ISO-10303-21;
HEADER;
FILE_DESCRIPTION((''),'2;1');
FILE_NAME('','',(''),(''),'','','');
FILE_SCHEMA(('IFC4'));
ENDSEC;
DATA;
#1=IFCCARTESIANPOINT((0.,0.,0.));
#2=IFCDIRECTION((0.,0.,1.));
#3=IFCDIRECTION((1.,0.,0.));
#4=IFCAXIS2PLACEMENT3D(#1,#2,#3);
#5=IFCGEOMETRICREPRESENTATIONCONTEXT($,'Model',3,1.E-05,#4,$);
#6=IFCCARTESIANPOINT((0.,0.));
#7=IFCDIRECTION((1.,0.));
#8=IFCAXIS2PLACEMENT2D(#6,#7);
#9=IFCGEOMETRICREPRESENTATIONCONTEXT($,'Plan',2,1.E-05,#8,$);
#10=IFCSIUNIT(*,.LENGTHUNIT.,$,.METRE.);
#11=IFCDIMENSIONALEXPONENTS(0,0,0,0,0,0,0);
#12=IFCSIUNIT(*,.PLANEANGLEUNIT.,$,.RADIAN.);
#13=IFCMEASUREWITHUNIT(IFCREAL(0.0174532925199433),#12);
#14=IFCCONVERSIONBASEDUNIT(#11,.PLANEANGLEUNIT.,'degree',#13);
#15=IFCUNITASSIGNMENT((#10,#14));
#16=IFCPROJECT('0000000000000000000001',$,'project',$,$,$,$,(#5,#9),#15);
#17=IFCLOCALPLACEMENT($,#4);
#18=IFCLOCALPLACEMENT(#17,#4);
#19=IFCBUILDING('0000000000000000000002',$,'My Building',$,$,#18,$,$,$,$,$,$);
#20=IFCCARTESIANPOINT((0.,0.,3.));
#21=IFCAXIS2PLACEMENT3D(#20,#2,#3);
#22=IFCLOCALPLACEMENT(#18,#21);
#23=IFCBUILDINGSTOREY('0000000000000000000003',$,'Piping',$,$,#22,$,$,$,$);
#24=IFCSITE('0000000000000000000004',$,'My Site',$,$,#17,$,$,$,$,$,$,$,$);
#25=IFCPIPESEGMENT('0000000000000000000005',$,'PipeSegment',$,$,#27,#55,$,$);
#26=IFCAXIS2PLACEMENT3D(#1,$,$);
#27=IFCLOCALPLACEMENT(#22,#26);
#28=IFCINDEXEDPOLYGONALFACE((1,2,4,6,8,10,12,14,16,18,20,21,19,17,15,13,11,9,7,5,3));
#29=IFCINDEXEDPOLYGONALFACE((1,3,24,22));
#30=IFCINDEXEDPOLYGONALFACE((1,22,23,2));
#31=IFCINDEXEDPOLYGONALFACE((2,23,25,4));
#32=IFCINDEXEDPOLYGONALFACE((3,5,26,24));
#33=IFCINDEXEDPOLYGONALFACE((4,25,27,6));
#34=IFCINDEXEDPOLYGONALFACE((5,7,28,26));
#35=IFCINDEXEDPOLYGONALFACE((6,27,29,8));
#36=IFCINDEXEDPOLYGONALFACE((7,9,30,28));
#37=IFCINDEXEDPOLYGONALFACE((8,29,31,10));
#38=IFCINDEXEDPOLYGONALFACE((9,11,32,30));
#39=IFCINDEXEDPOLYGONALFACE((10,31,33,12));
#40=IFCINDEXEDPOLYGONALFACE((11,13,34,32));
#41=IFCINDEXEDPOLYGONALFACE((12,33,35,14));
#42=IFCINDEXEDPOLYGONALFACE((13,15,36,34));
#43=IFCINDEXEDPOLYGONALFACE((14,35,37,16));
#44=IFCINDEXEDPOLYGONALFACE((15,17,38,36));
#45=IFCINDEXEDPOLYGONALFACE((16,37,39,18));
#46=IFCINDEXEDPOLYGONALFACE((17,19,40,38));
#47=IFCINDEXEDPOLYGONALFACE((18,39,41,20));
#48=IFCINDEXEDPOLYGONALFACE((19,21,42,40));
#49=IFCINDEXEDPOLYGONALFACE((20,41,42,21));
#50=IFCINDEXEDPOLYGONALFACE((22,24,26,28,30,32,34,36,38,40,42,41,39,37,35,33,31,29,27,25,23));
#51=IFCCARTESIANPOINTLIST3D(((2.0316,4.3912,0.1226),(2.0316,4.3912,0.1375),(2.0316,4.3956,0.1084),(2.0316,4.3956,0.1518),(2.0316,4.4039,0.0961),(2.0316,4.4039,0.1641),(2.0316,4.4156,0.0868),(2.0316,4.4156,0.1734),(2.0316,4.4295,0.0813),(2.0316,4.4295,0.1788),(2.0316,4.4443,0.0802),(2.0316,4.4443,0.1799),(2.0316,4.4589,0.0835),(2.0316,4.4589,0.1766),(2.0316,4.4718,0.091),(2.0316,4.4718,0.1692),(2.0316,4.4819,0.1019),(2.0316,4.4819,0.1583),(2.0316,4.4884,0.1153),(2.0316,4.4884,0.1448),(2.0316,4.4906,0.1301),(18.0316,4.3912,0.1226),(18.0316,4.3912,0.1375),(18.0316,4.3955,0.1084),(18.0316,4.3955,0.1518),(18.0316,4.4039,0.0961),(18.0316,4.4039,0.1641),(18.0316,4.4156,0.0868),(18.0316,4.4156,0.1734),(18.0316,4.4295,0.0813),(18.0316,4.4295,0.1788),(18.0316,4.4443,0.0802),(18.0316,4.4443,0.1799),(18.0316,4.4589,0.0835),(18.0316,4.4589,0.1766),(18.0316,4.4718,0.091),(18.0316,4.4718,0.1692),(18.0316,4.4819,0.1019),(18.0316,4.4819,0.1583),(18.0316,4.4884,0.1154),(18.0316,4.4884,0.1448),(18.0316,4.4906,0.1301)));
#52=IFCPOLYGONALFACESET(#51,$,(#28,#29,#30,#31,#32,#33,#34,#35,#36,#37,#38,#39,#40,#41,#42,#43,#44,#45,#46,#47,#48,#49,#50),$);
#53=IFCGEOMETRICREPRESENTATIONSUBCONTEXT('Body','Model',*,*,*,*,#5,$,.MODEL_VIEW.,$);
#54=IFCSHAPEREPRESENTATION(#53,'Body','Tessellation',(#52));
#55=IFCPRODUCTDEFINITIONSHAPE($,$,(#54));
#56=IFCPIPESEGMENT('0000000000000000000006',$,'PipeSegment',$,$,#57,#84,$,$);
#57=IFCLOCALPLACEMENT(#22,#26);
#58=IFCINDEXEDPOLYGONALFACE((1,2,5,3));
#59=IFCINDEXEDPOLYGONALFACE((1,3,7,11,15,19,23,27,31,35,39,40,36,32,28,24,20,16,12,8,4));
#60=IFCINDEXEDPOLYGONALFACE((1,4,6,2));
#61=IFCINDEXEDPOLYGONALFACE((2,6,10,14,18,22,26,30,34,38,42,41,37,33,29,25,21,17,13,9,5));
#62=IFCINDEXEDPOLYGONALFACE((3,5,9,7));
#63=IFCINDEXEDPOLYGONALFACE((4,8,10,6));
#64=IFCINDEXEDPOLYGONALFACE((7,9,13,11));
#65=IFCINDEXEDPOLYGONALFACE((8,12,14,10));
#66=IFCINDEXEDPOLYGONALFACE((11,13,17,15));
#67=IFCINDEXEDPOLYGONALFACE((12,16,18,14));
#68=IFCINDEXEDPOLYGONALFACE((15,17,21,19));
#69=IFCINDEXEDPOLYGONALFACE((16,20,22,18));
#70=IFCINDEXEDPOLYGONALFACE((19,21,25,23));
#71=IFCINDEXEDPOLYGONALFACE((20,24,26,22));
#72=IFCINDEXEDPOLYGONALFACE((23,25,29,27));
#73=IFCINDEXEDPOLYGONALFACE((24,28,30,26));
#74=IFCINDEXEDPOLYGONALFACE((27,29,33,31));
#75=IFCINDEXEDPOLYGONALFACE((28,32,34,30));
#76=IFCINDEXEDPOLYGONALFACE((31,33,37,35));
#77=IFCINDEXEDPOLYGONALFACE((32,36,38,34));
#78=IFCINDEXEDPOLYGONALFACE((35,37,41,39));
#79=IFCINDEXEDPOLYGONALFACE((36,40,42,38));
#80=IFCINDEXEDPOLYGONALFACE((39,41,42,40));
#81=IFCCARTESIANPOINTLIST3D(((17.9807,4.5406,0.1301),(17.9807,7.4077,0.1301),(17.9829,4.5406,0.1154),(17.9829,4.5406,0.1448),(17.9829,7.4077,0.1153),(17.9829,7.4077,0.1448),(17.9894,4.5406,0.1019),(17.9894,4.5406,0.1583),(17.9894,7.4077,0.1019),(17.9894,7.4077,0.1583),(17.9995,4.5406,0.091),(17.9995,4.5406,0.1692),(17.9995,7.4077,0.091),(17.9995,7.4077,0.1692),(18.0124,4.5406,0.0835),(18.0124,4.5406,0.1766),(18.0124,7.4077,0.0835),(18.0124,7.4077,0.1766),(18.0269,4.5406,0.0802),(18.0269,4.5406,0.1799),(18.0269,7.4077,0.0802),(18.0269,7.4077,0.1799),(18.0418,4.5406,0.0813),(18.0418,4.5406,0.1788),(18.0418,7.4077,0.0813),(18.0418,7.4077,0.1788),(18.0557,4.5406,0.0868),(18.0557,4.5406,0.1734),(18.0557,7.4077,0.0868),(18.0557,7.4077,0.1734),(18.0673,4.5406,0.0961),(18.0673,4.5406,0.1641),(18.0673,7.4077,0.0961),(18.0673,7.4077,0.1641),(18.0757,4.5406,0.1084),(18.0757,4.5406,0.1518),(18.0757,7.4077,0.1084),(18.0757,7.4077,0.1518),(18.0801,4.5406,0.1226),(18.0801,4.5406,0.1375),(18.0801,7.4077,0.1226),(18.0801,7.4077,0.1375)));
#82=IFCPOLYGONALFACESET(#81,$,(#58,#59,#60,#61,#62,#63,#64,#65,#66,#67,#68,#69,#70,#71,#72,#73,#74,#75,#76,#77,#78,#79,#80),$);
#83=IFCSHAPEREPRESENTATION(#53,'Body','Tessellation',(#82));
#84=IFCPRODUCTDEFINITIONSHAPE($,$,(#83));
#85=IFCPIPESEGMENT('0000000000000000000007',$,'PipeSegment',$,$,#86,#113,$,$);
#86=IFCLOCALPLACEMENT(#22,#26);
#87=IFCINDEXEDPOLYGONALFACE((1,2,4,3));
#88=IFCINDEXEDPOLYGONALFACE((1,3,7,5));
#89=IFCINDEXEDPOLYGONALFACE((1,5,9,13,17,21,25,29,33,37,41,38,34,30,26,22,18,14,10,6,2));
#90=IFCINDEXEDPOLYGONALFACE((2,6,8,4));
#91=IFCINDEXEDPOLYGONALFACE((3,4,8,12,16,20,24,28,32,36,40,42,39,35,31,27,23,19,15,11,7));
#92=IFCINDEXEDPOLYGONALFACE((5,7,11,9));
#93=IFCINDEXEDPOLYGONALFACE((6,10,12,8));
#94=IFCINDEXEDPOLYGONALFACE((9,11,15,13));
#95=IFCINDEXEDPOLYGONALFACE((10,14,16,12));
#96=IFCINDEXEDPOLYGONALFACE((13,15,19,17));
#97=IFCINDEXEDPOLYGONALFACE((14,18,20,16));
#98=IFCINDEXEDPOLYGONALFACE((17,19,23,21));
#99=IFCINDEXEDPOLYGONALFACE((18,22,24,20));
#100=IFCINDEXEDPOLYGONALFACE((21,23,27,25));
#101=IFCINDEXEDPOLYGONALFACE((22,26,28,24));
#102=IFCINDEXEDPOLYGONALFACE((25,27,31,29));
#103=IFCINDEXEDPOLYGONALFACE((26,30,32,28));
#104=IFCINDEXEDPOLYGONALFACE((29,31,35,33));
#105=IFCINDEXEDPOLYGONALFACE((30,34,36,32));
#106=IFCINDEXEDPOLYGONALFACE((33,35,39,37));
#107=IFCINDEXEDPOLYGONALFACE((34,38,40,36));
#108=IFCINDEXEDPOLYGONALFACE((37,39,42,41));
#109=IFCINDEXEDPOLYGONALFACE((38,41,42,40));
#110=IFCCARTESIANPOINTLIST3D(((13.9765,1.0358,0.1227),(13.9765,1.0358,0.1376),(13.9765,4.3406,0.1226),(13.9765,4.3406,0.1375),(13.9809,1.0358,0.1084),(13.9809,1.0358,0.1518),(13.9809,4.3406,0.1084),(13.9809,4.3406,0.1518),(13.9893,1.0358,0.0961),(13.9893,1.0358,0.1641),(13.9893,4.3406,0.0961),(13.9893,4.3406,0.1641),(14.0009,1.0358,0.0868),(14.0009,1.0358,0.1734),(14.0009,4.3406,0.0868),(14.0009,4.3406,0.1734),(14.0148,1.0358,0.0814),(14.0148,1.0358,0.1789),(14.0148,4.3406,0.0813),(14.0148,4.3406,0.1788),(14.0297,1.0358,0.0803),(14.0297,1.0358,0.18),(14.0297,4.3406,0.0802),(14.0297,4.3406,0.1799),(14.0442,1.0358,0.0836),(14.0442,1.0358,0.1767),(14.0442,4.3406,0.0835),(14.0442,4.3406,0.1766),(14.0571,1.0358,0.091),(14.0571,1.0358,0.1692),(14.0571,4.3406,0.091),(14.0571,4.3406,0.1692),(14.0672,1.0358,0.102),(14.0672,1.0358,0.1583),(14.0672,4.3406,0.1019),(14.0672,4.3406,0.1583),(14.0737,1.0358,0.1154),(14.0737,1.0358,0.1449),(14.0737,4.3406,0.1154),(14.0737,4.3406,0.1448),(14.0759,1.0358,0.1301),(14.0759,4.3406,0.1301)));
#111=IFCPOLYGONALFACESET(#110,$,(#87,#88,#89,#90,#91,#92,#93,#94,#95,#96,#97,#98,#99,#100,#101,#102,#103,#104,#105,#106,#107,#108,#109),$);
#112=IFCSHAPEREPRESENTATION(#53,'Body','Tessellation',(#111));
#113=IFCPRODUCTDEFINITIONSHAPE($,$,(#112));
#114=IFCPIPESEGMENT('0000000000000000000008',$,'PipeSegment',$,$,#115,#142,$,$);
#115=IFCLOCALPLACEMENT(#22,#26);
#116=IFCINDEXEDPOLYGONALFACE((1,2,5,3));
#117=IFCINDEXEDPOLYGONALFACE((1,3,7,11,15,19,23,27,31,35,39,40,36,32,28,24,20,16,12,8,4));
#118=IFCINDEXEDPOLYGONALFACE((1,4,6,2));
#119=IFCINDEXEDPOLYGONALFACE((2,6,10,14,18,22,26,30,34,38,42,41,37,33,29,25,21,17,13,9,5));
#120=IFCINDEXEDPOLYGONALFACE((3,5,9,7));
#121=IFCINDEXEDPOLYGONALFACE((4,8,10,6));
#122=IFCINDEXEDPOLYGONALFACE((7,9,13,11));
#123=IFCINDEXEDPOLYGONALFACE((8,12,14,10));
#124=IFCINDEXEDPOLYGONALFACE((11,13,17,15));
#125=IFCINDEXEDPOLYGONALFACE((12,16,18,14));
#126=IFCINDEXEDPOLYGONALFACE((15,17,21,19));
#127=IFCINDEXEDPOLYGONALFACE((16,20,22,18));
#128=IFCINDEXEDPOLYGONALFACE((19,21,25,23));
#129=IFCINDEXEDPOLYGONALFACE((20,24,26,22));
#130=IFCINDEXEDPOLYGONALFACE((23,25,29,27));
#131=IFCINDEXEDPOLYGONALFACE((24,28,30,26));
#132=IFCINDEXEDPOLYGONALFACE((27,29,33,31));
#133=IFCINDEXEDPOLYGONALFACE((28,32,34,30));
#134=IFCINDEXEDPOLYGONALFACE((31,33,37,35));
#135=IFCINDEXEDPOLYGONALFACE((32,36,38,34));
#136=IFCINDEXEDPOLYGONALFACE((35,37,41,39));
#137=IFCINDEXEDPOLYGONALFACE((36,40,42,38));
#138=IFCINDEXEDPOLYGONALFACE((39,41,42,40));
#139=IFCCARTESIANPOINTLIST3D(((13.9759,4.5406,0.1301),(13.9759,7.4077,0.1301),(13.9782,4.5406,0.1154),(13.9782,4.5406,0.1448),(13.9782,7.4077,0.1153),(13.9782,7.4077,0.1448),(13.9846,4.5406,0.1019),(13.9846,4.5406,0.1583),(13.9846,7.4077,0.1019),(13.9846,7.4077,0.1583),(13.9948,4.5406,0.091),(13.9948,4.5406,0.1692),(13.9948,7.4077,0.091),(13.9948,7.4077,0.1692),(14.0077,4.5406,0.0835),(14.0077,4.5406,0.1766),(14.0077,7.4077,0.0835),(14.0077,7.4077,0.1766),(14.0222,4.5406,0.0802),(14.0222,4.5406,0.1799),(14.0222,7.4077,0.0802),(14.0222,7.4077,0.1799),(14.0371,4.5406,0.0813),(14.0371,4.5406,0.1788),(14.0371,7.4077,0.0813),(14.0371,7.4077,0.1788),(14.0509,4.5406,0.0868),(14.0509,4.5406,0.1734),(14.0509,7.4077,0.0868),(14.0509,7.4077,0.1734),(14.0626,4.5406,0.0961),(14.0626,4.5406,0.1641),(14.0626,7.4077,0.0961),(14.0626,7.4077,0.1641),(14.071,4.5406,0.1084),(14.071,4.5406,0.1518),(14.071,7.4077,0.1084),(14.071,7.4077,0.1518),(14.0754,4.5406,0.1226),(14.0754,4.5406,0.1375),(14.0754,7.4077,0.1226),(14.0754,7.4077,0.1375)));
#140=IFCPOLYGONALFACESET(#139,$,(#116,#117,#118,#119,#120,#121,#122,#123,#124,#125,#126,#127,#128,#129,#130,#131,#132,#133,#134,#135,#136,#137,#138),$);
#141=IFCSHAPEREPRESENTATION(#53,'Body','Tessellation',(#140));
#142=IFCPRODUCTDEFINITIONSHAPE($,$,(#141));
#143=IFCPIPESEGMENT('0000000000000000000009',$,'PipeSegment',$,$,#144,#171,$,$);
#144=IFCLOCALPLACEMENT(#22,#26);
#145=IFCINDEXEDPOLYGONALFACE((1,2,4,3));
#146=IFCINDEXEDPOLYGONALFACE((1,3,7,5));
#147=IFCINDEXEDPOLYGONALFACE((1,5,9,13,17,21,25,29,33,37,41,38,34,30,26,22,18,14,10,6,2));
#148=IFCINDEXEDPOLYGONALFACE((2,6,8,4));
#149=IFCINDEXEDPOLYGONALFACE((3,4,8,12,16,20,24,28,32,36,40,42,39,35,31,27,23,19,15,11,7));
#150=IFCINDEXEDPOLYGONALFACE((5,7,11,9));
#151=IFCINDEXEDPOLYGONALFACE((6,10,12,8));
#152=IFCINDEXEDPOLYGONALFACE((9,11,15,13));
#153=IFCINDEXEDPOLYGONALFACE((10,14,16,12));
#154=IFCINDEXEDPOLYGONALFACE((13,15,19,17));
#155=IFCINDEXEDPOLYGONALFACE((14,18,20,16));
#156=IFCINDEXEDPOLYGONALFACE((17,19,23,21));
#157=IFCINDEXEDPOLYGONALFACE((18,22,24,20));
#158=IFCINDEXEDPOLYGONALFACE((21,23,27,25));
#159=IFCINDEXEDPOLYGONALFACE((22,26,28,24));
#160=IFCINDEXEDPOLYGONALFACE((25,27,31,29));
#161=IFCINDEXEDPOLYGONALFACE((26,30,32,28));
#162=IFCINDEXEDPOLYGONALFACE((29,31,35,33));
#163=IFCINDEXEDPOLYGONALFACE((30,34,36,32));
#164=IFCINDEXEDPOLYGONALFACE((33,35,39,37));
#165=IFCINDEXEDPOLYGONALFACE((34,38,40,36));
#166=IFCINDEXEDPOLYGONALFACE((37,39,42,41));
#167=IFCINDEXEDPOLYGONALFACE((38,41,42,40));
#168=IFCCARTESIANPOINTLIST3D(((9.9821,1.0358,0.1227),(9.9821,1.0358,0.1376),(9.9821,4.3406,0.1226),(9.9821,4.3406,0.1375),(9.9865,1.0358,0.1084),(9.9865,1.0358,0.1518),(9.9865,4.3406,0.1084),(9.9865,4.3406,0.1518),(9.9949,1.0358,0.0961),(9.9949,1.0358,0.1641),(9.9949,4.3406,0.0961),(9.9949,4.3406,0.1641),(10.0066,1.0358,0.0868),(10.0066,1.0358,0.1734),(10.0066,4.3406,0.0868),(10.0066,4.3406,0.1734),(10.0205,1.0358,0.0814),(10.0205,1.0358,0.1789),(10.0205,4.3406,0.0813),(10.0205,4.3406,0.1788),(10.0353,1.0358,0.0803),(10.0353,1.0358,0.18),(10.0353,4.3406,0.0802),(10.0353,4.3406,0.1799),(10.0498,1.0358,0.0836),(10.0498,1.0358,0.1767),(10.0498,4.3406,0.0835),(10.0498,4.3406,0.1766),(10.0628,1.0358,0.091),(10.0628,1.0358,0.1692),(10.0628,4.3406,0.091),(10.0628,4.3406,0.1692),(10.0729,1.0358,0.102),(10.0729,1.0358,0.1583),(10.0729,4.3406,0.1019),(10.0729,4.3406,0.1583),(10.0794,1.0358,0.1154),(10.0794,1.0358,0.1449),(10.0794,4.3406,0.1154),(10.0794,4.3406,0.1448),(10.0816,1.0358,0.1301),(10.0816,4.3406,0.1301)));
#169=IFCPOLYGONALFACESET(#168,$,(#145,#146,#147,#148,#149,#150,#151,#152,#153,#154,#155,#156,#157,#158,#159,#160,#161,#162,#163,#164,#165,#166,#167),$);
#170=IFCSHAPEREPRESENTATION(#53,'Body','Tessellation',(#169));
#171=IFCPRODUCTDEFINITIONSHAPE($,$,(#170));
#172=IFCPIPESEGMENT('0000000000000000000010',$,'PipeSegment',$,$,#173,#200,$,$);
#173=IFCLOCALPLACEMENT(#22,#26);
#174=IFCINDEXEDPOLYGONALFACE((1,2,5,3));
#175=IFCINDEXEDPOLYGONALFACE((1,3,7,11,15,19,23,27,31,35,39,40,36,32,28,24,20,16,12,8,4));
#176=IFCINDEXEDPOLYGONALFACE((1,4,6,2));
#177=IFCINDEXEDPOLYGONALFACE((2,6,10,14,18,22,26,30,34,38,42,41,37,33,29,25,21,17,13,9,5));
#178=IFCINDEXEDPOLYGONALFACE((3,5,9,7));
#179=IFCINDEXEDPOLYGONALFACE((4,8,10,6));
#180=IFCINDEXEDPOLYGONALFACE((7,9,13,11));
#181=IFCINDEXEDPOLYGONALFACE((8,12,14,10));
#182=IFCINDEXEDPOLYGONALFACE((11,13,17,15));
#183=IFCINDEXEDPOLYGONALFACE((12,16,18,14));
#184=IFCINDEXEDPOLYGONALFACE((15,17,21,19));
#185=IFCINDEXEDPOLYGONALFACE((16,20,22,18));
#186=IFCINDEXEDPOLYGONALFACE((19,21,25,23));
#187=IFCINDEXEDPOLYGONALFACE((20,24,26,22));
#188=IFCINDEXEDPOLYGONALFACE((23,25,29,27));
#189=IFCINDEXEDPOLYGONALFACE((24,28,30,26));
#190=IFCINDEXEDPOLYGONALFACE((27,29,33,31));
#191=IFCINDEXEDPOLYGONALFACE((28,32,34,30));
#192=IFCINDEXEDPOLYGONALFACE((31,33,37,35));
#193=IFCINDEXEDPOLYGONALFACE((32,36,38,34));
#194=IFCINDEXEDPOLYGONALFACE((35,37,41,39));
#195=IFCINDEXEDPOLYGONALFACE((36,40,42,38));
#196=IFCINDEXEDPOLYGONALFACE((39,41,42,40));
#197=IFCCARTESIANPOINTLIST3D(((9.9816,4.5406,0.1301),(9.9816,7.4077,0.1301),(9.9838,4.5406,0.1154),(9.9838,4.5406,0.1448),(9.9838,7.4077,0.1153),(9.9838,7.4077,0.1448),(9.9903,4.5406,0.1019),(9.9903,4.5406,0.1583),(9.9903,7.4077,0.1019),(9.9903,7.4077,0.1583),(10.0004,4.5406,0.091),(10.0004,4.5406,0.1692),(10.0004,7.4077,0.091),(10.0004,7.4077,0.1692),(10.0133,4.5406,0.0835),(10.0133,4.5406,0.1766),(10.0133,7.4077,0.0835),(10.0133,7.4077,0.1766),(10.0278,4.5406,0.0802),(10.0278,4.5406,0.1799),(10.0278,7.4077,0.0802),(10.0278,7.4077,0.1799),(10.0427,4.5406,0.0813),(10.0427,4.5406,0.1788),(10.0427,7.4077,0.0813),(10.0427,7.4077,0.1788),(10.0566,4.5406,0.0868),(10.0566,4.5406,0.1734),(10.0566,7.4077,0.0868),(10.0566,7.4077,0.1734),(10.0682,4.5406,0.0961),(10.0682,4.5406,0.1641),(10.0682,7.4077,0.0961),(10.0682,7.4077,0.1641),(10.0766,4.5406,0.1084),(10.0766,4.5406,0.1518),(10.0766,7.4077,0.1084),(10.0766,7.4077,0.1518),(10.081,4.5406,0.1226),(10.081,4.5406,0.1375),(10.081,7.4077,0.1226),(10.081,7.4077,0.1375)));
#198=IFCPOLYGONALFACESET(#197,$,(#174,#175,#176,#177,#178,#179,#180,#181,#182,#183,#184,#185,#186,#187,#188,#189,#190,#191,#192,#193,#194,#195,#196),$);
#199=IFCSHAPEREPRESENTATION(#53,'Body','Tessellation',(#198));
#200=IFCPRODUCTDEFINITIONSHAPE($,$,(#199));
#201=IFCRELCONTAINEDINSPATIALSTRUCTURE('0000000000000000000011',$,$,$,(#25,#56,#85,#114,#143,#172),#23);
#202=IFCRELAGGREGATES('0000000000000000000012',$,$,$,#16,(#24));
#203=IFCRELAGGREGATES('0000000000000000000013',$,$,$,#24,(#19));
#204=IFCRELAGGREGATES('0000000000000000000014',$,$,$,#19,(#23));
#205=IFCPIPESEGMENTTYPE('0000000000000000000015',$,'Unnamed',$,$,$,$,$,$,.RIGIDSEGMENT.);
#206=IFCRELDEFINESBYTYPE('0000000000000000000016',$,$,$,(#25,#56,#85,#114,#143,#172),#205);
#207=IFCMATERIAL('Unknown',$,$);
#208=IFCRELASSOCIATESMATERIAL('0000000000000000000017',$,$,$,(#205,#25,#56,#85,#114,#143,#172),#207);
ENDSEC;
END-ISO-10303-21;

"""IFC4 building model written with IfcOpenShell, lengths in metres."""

from ifc_helpers import new_model, entity, si_unit, converted_unit, frame, origin_with_axes, origin_2d_with_axis, place, context, subcontext, project, spatial, circle, extrude, material, material_profile, profile_set, profile_usage, type_object, element, save


model = new_model("IFC4")

# Units and contexts
model_context = context("Model", 3, precision=1e-05, world=origin_with_axes())
plan_context = context("Plan", 2, precision=1e-05, world=origin_2d_with_axis())
body_context = subcontext(model_context, "Body", "Model", "MODEL_VIEW")
ifc_project = project(units=[si_unit("LENGTHUNIT", "METRE"), converted_unit("PLANEANGLEUNIT", "degree", entity("IfcReal", 0.0174532925199433), si_unit("PLANEANGLEUNIT", "RADIAN"), dimensions=[0, 0, 0, 0, 0, 0, 0])], contexts=[model_context, plan_context])

# Site, building, storey
site_placement = place(None, origin_with_axes())
site = spatial("IfcSite", under=ifc_project, at=site_placement, Name="My Site")
building_placement = place(site_placement, origin_with_axes())
building = spatial("IfcBuilding", under=site, at=building_placement, Name="My Building")
storey_placement = place(building_placement, frame((0.0, 0.0, 3.0), z_axis=(0.0, 0.0, 1.0), x_axis=(1.0, 0.0, 0.0)))
storey = spatial("IfcBuildingStorey", under=building, at=storey_placement, Name="Piping")

# Pipe segments
ifc_material = material(Name="Unknown")
ifc_material_profile_1 = material_profile(ifc_material, circle(Radius=0.05))
ifc_profile_set_1 = profile_set([ifc_material_profile_1])
ifc_profile_usage_1 = profile_usage(ifc_profile_set_1, cardinal=5)
pipe_segment_type = type_object("IfcPipeSegmentType", Name="Unnamed", PredefinedType="RIGIDSEGMENT", material=ifc_profile_set_1)
pipe_segment_1_placement = place(storey_placement, frame((2.0316, 4.4406, 0.1301), z_axis=(1.0, 0.0, 0.0), x_axis=(0.0, 1.0, 0.0)))
element("IfcPipeSegment", 1, at=pipe_segment_1_placement, inside=storey, type_object=pipe_segment_type, material=ifc_profile_usage_1, Name="PipeSegment", context=body_context, shape_type="SweptSolid", body=[
    extrude(circle(Radius=0.05), origin_with_axes(), (0.0, 0.0, 1.0), 16.0),
])
ifc_profile_usage_2 = profile_usage(ifc_profile_set_1, cardinal=5)
pipe_segment_2_placement = place(storey_placement, frame((18.0307, 4.5406, 0.1301), z_axis=(0.0, 1.0, -0.000001), x_axis=(-1.0, 0.0, 0.0)))
element("IfcPipeSegment", 2, at=pipe_segment_2_placement, inside=storey, type_object=pipe_segment_type, material=ifc_profile_usage_2, Name="PipeSegment", context=body_context, shape_type="SweptSolid", body=[
    extrude(circle(Radius=0.05), origin_with_axes(), (0.0, 0.0, 1.0), 2.8671),
])
ifc_profile_usage_3 = profile_usage(ifc_profile_set_1, cardinal=5)
pipe_segment_3_placement = place(storey_placement, frame((14.0259, 4.3406, 0.1301), z_axis=(0.0, -1.0, 0.000015), x_axis=(1.0, 0.0, 0.0)))
element("IfcPipeSegment", 3, at=pipe_segment_3_placement, inside=storey, type_object=pipe_segment_type, material=ifc_profile_usage_3, Name="PipeSegment", context=body_context, shape_type="SweptSolid", body=[
    extrude(circle(Radius=0.05), origin_with_axes(), (0.0, 0.0, 1.0), 3.3048),
])
ifc_profile_usage_4 = profile_usage(ifc_profile_set_1, cardinal=5)
pipe_segment_4_placement = place(storey_placement, frame((14.0259, 4.5406, 0.1301), z_axis=(0.0, 1.0, -0.000001), x_axis=(-1.0, 0.0, 0.0)))
element("IfcPipeSegment", 4, at=pipe_segment_4_placement, inside=storey, type_object=pipe_segment_type, material=ifc_profile_usage_4, Name="PipeSegment", context=body_context, shape_type="SweptSolid", body=[
    extrude(circle(Radius=0.05), origin_with_axes(), (0.0, 0.0, 1.0), 2.8671),
])
ifc_profile_usage_5 = profile_usage(ifc_profile_set_1, cardinal=5)
pipe_segment_5_placement = place(storey_placement, frame((10.0316, 4.3406, 0.1301), z_axis=(0.0, -1.0, 0.000015), x_axis=(1.0, 0.0, 0.0)))
element("IfcPipeSegment", 5, at=pipe_segment_5_placement, inside=storey, type_object=pipe_segment_type, material=ifc_profile_usage_5, Name="PipeSegment", context=body_context, shape_type="SweptSolid", body=[
    extrude(circle(Radius=0.05), origin_with_axes(), (0.0, 0.0, 1.0), 3.3048),
])
ifc_profile_usage_6 = profile_usage(ifc_profile_set_1, cardinal=5)
pipe_segment_6_placement = place(storey_placement, frame((10.0316, 4.5406, 0.1301), z_axis=(0.0, 1.0, -0.000001), x_axis=(-1.0, 0.0, 0.0)))
element("IfcPipeSegment", 6, at=pipe_segment_6_placement, inside=storey, type_object=pipe_segment_type, material=ifc_profile_usage_6, Name="PipeSegment", context=body_context, shape_type="SweptSolid", body=[
    extrude(circle(Radius=0.05), origin_with_axes(), (0.0, 0.0, 1.0), 2.8671),
])

save(model, "model.ifc")
